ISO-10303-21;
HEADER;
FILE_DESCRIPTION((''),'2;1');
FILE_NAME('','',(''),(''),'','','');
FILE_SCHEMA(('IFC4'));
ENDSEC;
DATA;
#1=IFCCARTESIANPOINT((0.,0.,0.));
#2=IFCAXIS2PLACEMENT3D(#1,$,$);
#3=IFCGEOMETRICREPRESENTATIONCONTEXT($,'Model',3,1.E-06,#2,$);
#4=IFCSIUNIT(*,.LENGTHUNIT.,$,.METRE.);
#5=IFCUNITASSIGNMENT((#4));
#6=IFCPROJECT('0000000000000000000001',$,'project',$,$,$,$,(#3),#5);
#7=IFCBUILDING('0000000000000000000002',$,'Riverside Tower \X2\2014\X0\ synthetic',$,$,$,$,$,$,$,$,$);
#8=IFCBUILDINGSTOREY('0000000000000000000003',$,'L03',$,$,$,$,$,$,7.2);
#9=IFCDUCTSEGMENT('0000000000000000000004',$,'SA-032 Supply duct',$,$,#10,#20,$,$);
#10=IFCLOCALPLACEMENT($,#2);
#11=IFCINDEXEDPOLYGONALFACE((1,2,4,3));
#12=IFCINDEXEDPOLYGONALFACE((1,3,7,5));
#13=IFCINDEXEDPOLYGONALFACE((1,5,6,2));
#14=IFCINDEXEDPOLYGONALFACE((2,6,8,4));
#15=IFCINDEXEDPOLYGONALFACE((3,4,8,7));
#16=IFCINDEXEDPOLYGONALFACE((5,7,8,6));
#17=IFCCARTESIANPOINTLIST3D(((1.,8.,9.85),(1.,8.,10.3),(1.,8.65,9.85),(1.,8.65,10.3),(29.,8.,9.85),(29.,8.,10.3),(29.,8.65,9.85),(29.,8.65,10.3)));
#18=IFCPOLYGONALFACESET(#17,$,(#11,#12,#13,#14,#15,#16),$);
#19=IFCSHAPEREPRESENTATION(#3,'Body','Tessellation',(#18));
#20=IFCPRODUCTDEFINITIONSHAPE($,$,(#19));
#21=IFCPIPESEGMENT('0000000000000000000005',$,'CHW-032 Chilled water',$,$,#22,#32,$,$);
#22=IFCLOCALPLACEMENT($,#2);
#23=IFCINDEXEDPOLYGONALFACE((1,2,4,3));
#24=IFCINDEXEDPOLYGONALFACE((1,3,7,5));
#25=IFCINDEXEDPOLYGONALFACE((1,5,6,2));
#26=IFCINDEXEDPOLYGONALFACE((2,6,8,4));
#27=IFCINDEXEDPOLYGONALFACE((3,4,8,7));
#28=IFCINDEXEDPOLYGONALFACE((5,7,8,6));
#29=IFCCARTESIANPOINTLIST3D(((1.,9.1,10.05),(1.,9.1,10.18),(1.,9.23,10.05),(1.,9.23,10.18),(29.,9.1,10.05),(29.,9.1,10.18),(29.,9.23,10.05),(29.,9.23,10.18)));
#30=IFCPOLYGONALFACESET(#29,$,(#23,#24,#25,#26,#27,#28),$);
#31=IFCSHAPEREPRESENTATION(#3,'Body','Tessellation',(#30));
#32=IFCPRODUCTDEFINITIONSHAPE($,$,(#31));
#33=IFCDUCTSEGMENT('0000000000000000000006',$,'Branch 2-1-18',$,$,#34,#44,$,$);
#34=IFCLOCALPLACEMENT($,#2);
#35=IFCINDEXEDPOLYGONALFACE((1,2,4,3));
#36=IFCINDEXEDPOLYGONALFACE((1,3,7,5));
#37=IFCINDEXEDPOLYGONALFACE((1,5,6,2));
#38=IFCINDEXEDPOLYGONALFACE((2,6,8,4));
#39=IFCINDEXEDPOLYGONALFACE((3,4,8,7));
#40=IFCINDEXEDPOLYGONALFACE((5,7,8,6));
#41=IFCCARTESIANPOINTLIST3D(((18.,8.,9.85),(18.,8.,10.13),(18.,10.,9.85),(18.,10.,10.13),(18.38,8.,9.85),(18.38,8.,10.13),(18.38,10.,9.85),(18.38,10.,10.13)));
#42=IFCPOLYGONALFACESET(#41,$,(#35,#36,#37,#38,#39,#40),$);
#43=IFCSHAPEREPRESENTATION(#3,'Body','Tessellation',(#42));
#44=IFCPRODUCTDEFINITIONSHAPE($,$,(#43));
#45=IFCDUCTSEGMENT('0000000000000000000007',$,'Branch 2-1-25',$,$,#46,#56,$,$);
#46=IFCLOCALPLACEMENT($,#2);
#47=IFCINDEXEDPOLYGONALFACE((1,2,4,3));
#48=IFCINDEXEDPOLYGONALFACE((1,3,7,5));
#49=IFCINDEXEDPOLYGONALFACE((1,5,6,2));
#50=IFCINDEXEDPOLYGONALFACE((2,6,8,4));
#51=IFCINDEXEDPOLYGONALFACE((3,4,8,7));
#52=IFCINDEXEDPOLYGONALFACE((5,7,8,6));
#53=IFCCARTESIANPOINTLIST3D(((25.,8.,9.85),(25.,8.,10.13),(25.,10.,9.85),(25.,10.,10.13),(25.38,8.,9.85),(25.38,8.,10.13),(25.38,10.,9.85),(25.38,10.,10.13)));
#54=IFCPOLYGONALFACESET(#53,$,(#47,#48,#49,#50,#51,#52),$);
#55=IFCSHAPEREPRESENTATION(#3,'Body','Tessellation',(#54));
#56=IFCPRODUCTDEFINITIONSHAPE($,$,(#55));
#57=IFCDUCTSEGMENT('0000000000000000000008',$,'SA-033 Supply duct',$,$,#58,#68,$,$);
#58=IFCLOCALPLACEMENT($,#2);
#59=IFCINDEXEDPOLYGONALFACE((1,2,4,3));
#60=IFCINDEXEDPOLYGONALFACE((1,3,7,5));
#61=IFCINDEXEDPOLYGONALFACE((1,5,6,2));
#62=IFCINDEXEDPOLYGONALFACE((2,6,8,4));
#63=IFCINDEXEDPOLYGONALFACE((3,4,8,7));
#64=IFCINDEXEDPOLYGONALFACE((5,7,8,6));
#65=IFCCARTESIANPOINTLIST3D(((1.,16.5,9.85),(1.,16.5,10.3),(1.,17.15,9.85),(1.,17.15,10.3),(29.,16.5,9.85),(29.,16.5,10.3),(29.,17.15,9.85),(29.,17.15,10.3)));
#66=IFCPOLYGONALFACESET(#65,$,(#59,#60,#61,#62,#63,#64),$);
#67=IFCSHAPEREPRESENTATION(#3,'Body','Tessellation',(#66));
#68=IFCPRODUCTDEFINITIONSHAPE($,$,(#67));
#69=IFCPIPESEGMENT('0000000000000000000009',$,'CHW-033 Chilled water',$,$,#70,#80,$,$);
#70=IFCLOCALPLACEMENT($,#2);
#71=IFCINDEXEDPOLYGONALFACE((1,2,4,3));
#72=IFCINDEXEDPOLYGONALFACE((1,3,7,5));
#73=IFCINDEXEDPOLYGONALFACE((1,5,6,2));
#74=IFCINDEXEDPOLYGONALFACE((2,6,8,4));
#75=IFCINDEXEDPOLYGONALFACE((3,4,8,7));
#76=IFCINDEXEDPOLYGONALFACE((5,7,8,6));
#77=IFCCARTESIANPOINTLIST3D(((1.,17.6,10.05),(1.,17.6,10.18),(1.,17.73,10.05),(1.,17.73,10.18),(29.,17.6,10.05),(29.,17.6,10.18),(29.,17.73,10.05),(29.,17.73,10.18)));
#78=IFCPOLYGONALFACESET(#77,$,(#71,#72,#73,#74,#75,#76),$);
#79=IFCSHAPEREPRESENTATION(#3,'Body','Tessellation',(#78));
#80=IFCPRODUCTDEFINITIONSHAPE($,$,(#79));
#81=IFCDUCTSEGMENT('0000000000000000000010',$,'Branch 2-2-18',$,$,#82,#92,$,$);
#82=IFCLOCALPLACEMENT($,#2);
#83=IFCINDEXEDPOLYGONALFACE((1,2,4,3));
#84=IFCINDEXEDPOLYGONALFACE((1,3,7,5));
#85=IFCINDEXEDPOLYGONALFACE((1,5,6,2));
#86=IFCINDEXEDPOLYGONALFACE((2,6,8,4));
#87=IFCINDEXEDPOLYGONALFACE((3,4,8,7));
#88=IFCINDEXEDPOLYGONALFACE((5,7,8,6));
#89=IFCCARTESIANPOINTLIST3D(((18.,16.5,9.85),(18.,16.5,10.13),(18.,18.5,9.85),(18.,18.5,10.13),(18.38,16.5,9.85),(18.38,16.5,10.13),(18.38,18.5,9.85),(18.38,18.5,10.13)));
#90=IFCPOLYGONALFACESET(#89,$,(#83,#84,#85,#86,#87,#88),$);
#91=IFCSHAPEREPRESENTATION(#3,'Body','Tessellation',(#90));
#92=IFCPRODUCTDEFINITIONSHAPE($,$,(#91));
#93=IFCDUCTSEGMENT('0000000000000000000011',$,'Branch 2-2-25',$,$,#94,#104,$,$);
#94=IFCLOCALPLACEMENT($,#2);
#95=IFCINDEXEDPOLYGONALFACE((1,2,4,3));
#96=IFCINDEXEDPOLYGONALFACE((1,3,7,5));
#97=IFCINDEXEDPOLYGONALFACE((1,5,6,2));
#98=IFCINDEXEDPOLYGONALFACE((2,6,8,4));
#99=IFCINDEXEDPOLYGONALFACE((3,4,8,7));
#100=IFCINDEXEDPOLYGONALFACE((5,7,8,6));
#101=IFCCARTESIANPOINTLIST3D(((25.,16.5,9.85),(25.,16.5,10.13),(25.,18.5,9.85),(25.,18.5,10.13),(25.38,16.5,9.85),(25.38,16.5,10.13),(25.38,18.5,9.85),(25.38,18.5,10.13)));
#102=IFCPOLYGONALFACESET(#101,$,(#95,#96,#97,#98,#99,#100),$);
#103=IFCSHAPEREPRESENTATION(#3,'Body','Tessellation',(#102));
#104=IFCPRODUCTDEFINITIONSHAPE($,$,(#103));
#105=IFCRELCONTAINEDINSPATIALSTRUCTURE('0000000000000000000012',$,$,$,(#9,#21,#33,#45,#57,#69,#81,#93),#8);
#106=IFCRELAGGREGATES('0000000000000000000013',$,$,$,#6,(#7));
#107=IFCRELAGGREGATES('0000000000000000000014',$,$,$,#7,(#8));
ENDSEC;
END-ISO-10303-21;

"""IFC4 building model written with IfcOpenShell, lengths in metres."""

from ifc_helpers import new_model, si_unit, frame, origin, place, context, project, spatial, rectangle, extrude, element, save


model = new_model("IFC4")

# Units and contexts
model_context = context("Model", 3, precision=1e-06, world=origin())
ifc_project = project(units=[si_unit("LENGTHUNIT", "METRE")], contexts=[model_context])

# Building, storey
building = spatial("IfcBuilding", under=ifc_project, Name="Riverside Tower — synthetic")
storey = spatial("IfcBuildingStorey", under=building, Name="L03", Elevation=7.2)

# Duct segment
duct_segment_1_placement = place(None, frame((15.0, 8.325, 9.85)))
element("IfcDuctSegment", 1, at=duct_segment_1_placement, inside=storey, Name="SA-032 Supply duct", context=model_context, shape_type="SweptSolid", body=[
    extrude(rectangle(XDim=28.0, YDim=0.65), origin(), (0.0, 0.0, 1.0), 0.45),
])

# Pipe segment
pipe_segment_1_placement = place(None, frame((15.0, 9.165, 10.05)))
element("IfcPipeSegment", 2, at=pipe_segment_1_placement, inside=storey, Name="CHW-032 Chilled water", context=model_context, shape_type="SweptSolid", body=[
    extrude(rectangle(XDim=28.0, YDim=0.13), origin(), (0.0, 0.0, 1.0), 0.13),
])

# Duct segments
for number, where, name in (
    (3, (18.19, 9.0, 9.85), "Branch 2-1-18"),
    (4, (25.19, 9.0, 9.85), "Branch 2-1-25"),
):
    element("IfcDuctSegment", number, at=place(None, frame(where)), inside=storey, Name=name, context=model_context, shape_type="SweptSolid", body=[
        extrude(rectangle(XDim=0.38, YDim=2.0), origin(), (0.0, 0.0, 1.0), 0.28),
    ])
duct_segment_2_placement = place(None, frame((15.0, 16.825, 9.85)))
element("IfcDuctSegment", 5, at=duct_segment_2_placement, inside=storey, Name="SA-033 Supply duct", context=model_context, shape_type="SweptSolid", body=[
    extrude(rectangle(XDim=28.0, YDim=0.65), origin(), (0.0, 0.0, 1.0), 0.45),
])

# Pipe segment
pipe_segment_2_placement = place(None, frame((15.0, 17.665, 10.05)))
element("IfcPipeSegment", 6, at=pipe_segment_2_placement, inside=storey, Name="CHW-033 Chilled water", context=model_context, shape_type="SweptSolid", body=[
    extrude(rectangle(XDim=28.0, YDim=0.13), origin(), (0.0, 0.0, 1.0), 0.13),
])

# Duct segments
for number, where, name in (
    (7, (18.19, 17.5, 9.85), "Branch 2-2-18"),
    (8, (25.19, 17.5, 9.85), "Branch 2-2-25"),
):
    element("IfcDuctSegment", number, at=place(None, frame(where)), inside=storey, Name=name, context=model_context, shape_type="SweptSolid", body=[
        extrude(rectangle(XDim=0.38, YDim=2.0), origin(), (0.0, 0.0, 1.0), 0.28),
    ])

save(model, "model.ifc")
